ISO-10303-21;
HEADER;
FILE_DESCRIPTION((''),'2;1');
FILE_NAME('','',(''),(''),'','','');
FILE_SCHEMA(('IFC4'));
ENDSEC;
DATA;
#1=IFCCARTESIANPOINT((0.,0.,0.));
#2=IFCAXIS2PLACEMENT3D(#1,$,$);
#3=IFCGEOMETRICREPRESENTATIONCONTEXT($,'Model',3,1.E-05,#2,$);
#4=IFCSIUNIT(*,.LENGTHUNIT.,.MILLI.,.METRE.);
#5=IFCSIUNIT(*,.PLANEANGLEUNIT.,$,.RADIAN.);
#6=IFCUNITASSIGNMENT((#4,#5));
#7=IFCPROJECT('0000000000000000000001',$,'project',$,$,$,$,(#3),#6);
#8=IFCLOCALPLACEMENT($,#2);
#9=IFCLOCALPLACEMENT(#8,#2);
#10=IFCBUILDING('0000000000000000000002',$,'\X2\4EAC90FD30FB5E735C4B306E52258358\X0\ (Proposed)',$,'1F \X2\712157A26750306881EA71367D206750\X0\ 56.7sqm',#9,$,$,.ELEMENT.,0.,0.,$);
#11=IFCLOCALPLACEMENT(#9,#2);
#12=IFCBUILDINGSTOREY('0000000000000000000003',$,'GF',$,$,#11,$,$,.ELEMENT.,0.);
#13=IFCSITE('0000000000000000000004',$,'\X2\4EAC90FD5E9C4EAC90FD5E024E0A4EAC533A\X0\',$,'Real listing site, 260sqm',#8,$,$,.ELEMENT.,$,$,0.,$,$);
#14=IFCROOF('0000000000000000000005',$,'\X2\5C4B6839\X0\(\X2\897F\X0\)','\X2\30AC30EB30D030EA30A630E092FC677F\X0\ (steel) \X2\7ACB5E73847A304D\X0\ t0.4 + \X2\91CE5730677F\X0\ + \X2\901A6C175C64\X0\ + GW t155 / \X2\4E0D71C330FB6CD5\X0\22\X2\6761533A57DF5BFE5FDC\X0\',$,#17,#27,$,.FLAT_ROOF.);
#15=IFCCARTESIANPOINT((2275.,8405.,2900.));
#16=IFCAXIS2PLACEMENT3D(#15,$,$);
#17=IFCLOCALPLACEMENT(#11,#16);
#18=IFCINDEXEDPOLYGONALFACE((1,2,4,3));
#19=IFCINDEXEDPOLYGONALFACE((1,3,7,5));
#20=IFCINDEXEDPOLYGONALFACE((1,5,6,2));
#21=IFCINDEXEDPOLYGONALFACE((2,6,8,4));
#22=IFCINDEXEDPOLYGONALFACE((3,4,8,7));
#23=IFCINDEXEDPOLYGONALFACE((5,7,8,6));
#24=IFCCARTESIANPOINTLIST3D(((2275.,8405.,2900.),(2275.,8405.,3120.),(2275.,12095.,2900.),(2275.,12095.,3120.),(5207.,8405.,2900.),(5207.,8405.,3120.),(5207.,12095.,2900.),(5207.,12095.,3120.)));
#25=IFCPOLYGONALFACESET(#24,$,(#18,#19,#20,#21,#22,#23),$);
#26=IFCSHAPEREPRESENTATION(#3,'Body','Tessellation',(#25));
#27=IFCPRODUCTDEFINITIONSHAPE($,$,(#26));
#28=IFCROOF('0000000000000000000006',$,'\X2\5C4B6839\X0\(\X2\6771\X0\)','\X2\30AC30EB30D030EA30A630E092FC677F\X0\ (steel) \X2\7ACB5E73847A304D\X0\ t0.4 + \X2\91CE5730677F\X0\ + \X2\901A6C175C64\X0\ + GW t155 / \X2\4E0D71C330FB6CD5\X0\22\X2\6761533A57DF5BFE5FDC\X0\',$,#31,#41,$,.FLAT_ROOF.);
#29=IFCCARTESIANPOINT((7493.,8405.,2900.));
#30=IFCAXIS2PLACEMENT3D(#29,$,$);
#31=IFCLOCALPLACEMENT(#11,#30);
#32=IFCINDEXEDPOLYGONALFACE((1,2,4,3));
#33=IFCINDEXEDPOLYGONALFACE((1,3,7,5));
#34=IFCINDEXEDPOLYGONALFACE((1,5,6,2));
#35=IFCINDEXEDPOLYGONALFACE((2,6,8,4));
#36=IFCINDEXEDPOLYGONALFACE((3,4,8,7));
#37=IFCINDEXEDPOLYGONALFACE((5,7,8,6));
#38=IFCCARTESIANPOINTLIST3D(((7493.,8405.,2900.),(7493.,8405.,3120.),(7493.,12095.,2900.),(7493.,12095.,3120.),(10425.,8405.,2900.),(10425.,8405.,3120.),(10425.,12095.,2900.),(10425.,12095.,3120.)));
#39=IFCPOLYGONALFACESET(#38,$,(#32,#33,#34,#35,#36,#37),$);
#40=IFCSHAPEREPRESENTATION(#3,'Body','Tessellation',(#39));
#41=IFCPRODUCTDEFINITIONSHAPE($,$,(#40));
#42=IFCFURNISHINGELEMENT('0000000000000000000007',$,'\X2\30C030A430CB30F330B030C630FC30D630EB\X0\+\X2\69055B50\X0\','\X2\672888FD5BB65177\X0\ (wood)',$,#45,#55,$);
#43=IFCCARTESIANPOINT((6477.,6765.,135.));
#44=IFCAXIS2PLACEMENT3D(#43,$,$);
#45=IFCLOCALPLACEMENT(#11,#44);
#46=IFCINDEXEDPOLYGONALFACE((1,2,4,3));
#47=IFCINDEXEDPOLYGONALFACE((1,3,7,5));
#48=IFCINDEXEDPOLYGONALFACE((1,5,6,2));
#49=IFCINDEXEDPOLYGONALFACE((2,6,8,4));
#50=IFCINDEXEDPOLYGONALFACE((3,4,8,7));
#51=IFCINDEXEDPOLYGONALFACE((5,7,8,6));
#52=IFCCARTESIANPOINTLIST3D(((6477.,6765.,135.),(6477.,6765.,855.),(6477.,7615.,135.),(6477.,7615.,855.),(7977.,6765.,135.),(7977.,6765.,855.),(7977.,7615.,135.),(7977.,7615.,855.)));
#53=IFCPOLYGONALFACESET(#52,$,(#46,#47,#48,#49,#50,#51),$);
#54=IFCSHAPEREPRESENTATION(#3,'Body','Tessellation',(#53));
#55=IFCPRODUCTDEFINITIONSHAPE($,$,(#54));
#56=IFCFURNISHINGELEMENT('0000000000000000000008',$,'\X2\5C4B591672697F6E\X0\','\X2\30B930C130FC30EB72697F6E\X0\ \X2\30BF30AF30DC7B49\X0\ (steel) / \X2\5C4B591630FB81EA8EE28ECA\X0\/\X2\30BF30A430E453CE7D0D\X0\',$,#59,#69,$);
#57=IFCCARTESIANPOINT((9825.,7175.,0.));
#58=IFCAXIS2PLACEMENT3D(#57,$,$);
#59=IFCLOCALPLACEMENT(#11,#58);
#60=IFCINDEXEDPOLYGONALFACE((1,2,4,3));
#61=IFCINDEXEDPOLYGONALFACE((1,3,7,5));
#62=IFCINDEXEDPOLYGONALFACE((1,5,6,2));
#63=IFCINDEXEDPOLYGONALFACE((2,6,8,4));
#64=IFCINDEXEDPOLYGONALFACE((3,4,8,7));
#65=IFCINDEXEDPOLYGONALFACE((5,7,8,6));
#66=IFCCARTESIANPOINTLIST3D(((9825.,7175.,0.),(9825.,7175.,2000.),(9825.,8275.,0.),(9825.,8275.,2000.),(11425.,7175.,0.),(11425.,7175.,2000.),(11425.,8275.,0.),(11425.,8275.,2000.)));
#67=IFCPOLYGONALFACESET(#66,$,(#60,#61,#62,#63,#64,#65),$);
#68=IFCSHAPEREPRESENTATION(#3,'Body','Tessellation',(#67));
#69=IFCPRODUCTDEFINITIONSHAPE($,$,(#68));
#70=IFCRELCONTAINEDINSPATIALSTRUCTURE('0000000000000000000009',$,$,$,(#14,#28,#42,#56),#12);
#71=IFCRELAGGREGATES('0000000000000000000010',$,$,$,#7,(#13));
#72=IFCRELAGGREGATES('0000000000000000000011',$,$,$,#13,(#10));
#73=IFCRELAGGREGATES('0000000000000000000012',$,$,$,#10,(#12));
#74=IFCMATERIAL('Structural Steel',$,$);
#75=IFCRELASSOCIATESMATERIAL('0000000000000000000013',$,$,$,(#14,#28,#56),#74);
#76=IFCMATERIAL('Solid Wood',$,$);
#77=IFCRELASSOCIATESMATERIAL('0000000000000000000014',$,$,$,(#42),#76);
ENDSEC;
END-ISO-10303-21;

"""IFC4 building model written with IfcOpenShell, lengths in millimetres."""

from ifc_helpers import new_model, si_unit, frame, frame_2d, origin, place, context, project, spatial, rectangle, extrude, material, element, save


model = new_model("IFC4")

# Units and contexts
model_context = context("Model", 3, precision=1e-05, world=origin())
ifc_project = project(units=[si_unit("LENGTHUNIT", "METRE", prefix="MILLI"), si_unit("PLANEANGLEUNIT", "RADIAN")], contexts=[model_context])

# Site, building, storey
site_placement = place(None, origin())
site = spatial("IfcSite", under=ifc_project, at=site_placement, Name="京都府京都市上京区", ObjectType="Real listing site, 260sqm", CompositionType="ELEMENT", RefElevation=0.0)
building_placement = place(site_placement, origin())
building = spatial("IfcBuilding", under=site, at=building_placement, Name="京都・平屋の別荘 (Proposed)", ObjectType="1F 無垢材と自然素材 56.7sqm", CompositionType="ELEMENT", ElevationOfRefHeight=0.0, ElevationOfTerrain=0.0)
storey_placement = place(building_placement, origin())
storey = spatial("IfcBuildingStorey", under=building, at=storey_placement, Name="GF", CompositionType="ELEMENT", Elevation=0.0)

# Shared definitions
ifc_material_1 = material(Name="Solid Wood")

# Roofs
ifc_material_2 = material(Name="Structural Steel")
roof_1_placement = place(storey_placement, frame((2275.0, 8405.0, 2900.0)))
element("IfcRoof", 1, at=roof_1_placement, inside=storey, material=ifc_material_2, Name="屋根(西)", Description="ガルバリウム鋼板 (steel) 立平葺き t0.4 + 野地板 + 通気層 + GW t155 / 不燃・法22条区域対応", PredefinedType="FLAT_ROOF", context=model_context, shape_type="SweptSolid", body=[
    extrude(rectangle(XDim=2932.0, YDim=3690.0, at=frame_2d((1466.0, 1845.0))), frame((2275.0, 8405.0, 2900.0)), (0.0, 0.0, 1.0), 220.0),
])
roof_2_placement = place(storey_placement, frame((7493.0, 8405.0, 2900.0)))
element("IfcRoof", 2, at=roof_2_placement, inside=storey, material=ifc_material_2, Name="屋根(東)", Description="ガルバリウム鋼板 (steel) 立平葺き t0.4 + 野地板 + 通気層 + GW t155 / 不燃・法22条区域対応", PredefinedType="FLAT_ROOF", context=model_context, shape_type="SweptSolid", body=[
    extrude(rectangle(XDim=2932.0, YDim=3690.0, at=frame_2d((1466.0, 1845.0))), frame((7493.0, 8405.0, 2900.0)), (0.0, 0.0, 1.0), 220.0),
])

# Furnishing elements
furnishing_1_placement = place(storey_placement, frame((6477.0, 6765.0, 135.0)))
element("IfcFurnishingElement", 3, at=furnishing_1_placement, inside=storey, material=ifc_material_1, Name="ダイニングテーブル+椅子", Description="木製家具 (wood)", context=model_context, shape_type="SweptSolid", body=[
    extrude(rectangle(XDim=1500.0, YDim=850.0, at=frame_2d((750.0, 425.0))), frame((6477.0, 6765.0, 135.0)), (0.0, 0.0, 1.0), 720.0),
])
furnishing_2_placement = place(storey_placement, frame((9825.0, 7175.0, 0.0)))
element("IfcFurnishingElement", 4, at=furnishing_2_placement, inside=storey, material=ifc_material_2, Name="屋外物置", Description="スチール物置 タクボ等 (steel) / 屋外・自転車/タイヤ収納", context=model_context, shape_type="SweptSolid", body=[
    extrude(rectangle(XDim=1600.0, YDim=1100.0, at=frame_2d((800.0, 550.0))), frame((9825.0, 7175.0, 0.0)), (0.0, 0.0, 1.0), 2000.0),
])

save(model, "model.ifc")
